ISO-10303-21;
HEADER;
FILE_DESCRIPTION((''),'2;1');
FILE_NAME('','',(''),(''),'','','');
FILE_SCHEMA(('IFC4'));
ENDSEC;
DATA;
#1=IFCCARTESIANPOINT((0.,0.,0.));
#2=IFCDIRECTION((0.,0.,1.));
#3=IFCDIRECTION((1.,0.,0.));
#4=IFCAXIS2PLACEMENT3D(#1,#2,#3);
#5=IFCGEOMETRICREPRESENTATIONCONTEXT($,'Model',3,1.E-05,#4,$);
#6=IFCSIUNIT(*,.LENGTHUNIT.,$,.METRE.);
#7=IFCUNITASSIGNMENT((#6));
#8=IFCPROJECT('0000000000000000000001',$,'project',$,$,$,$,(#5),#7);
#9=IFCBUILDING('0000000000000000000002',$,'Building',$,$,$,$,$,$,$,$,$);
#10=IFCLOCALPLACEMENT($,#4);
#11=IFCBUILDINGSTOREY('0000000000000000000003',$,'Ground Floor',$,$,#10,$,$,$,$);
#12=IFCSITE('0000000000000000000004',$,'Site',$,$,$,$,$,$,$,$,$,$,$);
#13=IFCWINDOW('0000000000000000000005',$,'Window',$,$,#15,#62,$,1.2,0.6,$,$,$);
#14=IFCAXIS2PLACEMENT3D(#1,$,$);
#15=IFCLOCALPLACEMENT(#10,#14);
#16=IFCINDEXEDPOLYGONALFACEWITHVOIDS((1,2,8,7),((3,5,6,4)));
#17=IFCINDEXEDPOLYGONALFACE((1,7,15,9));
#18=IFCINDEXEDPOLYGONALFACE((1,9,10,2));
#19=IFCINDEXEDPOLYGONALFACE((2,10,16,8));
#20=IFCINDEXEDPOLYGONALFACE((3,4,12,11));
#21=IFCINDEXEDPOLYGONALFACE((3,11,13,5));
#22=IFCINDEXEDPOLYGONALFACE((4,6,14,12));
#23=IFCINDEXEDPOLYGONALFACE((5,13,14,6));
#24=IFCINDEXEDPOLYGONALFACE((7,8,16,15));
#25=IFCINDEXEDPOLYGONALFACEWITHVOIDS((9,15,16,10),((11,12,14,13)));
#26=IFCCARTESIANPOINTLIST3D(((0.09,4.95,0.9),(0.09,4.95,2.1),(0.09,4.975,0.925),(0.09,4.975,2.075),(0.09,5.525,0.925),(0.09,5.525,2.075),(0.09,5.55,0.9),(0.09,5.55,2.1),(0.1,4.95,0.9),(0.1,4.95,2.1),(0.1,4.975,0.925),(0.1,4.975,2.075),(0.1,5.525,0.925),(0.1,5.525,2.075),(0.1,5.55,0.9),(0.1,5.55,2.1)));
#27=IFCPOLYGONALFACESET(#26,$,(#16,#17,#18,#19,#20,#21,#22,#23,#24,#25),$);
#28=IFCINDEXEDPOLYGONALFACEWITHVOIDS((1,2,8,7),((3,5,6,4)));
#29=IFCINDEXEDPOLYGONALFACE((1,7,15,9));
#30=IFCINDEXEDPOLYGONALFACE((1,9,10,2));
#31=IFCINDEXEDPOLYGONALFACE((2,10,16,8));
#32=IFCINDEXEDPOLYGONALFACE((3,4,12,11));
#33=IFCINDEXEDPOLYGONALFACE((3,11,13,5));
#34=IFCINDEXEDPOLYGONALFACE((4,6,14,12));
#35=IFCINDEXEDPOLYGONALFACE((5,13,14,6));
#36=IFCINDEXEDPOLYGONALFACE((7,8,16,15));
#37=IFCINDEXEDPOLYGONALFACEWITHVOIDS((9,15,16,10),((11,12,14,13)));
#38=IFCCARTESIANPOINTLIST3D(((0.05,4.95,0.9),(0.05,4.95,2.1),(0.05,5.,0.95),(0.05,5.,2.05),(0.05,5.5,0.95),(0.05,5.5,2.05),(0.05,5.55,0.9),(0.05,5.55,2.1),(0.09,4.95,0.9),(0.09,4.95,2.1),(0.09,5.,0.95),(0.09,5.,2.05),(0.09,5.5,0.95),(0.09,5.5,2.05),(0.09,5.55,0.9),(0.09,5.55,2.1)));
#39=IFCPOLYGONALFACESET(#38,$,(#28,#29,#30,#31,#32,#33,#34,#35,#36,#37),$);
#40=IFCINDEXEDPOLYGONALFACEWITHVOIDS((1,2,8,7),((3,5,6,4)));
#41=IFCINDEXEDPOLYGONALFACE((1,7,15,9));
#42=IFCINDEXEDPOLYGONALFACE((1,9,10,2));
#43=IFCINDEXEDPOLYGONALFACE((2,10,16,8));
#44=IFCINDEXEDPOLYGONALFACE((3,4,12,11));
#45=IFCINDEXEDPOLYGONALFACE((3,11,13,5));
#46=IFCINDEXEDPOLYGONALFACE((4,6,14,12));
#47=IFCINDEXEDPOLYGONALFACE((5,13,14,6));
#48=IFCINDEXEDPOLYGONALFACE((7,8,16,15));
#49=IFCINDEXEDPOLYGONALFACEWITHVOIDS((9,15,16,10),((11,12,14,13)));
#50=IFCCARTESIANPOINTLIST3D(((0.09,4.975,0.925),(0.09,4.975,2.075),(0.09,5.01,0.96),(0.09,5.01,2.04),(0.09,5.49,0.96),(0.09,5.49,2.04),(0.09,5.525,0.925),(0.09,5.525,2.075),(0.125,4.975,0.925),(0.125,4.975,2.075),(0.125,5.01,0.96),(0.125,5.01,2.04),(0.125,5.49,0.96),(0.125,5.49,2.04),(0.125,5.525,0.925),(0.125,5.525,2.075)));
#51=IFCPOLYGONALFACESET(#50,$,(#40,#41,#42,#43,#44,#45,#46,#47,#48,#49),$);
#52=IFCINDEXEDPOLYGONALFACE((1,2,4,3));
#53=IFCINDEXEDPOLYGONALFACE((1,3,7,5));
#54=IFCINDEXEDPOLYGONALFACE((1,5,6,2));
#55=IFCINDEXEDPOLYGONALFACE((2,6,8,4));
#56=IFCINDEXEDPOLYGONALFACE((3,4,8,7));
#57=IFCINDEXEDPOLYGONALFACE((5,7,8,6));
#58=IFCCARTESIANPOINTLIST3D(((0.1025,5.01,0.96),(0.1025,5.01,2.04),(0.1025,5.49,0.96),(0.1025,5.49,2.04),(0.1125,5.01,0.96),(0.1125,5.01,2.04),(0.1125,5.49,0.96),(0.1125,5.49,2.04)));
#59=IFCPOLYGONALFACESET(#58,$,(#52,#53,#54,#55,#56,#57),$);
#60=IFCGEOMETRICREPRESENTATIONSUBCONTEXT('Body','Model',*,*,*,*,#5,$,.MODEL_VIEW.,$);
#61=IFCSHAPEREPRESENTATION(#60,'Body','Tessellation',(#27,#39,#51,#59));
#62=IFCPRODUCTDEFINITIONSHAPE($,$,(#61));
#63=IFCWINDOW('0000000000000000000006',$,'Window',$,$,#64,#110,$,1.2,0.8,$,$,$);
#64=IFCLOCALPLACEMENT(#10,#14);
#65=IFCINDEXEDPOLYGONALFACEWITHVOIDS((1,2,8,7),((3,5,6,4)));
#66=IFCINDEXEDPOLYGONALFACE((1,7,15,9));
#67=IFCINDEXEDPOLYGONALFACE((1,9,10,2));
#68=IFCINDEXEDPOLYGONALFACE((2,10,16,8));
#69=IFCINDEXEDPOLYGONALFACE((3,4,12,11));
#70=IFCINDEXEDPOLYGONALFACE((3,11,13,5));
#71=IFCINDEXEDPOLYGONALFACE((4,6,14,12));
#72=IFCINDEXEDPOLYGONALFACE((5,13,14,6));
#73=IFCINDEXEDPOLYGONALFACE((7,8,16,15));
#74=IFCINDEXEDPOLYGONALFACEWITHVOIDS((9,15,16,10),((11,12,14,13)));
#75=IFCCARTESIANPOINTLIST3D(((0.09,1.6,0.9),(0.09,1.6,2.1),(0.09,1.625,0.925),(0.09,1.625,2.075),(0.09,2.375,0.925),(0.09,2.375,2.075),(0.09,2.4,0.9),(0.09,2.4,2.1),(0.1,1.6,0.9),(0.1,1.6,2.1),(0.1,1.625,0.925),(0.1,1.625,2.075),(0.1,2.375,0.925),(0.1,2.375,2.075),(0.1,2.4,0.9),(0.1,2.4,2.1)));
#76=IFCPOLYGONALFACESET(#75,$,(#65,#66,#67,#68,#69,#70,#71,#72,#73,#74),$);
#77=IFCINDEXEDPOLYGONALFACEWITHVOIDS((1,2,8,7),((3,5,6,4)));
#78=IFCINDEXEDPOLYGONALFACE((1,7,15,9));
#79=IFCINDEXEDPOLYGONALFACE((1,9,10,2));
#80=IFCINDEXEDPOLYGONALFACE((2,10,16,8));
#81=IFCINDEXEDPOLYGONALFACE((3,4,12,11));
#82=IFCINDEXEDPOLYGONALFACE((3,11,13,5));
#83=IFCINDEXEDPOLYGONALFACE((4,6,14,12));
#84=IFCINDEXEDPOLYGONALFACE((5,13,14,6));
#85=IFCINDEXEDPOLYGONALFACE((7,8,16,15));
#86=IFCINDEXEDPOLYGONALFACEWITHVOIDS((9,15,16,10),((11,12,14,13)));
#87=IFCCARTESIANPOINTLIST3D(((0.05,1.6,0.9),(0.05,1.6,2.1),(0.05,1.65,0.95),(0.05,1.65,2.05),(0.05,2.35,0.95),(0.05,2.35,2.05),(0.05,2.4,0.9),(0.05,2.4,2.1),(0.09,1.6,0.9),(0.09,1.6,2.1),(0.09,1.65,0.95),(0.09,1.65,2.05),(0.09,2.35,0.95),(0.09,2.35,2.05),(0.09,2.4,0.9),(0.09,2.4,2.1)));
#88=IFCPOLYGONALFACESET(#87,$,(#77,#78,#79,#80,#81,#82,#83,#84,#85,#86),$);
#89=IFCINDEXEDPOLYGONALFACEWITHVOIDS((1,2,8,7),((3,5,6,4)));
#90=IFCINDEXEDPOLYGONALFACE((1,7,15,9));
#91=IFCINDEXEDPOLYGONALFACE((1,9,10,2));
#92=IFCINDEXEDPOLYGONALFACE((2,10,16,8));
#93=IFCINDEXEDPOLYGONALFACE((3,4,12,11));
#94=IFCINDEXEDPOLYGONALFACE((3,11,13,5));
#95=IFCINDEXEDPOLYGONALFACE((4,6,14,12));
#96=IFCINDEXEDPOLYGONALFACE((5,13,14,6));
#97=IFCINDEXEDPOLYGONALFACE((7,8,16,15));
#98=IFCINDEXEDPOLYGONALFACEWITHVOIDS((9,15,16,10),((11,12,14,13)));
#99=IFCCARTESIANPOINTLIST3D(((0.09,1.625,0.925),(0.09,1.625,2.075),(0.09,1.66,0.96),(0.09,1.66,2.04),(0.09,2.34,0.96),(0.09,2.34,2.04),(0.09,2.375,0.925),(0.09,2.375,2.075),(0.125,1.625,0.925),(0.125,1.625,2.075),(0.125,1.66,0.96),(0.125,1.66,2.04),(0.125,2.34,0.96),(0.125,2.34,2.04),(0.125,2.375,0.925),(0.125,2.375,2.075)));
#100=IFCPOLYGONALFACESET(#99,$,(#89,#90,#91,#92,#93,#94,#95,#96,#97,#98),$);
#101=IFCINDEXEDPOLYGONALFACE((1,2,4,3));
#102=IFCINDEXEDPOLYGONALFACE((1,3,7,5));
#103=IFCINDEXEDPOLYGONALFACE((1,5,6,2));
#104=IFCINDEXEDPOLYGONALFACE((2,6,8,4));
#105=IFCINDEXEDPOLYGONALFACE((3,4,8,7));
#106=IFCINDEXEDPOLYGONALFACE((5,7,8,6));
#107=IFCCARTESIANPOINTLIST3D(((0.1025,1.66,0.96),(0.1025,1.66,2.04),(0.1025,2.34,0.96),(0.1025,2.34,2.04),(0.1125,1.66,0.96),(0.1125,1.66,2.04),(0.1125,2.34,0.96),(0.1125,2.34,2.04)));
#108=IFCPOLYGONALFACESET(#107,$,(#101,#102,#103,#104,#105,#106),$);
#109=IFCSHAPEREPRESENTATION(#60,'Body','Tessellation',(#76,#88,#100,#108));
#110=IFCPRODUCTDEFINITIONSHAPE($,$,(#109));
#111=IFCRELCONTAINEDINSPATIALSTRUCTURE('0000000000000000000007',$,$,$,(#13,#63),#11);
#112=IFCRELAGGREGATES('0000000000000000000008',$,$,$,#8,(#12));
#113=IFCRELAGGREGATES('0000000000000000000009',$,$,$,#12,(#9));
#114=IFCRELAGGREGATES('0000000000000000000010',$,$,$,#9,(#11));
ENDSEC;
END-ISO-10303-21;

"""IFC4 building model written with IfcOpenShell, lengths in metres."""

from ifc_helpers import new_model, si_unit, frame, origin_with_axes, place, context, subcontext, project, spatial, line, indexed_curve, outline, extrude, element, save


model = new_model("IFC4")

# Units and contexts
model_context = context("Model", 3, precision=1e-05, world=origin_with_axes())
body_context = subcontext(model_context, "Body", "Model", "MODEL_VIEW")
ifc_project = project(units=[si_unit("LENGTHUNIT", "METRE")], contexts=[model_context])

# Site, building, storey
site = spatial("IfcSite", under=ifc_project, Name="Site")
building = spatial("IfcBuilding", under=site, Name="Building")
storey_placement = place(None, origin_with_axes())
storey = spatial("IfcBuildingStorey", under=building, at=storey_placement, Name="Ground Floor")

# Windows
window_1_placement = place(storey_placement, frame((0.0, 5.55, 0.9), z_axis=(0.0, 0.0, 1.0), x_axis=(0.0, -1.0, 0.0)))
element("IfcWindow", 1, at=window_1_placement, inside=storey, Name="Window", OverallHeight=1.2, OverallWidth=0.6, context=body_context, shape_type="SweptSolid", body=[
    extrude(outline(indexed_curve([(0.0, 0.0), (0.6, 0.0), (0.6, 1.2), (0.0, 1.2)], segments=[line(1, 2, 3, 4, 1)]), holes=[indexed_curve([(0.025, 0.025), (0.575, 0.025), (0.575, 1.175), (0.025, 1.175)], segments=[line(1, 2, 3, 4, 1)])]), frame((0.0, 0.09, 0.0), z_axis=(0.0, -1.0, 0.0), x_axis=(1.0, 0.0, 0.0)), (0.0, 0.0, -1.0), 0.01),
    extrude(outline(indexed_curve([(0.0, 0.0), (0.6, 0.0), (0.6, 1.2), (0.0, 1.2)], segments=[line(1, 2, 3, 4, 1)]), holes=[indexed_curve([(0.05, 0.05), (0.55, 0.05), (0.55, 1.15), (0.05, 1.15)], segments=[line(1, 2, 3, 4, 1)])]), frame((0.0, 0.05, 0.0), z_axis=(0.0, -1.0, 0.0), x_axis=(1.0, 0.0, 0.0)), (0.0, 0.0, -1.0), 0.04),
    extrude(outline(indexed_curve([(0.0, 0.0), (0.55, 0.0), (0.55, 1.15), (0.0, 1.15)], segments=[line(1, 2, 3, 4, 1)]), holes=[indexed_curve([(0.035, 0.035), (0.515, 0.035), (0.515, 1.115), (0.035, 1.115)], segments=[line(1, 2, 3, 4, 1)])]), frame((0.025, 0.09, 0.025), z_axis=(0.0, -1.0, 0.0), x_axis=(1.0, 0.0, 0.0)), (0.0, 0.0, -1.0), 0.035),
    extrude(outline(indexed_curve([(0.035, 0.035), (0.515, 0.035), (0.515, 1.115), (0.035, 1.115)], segments=[line(1, 2, 3, 4, 1)])), frame((0.025, 0.1025, 0.025), z_axis=(0.0, -1.0, 0.0), x_axis=(1.0, 0.0, 0.0)), (0.0, 0.0, -1.0), 0.01),
])
window_2_placement = place(storey_placement, frame((0.0, 2.4, 0.9), z_axis=(0.0, 0.0, 1.0), x_axis=(0.0, -1.0, 0.0)))
element("IfcWindow", 2, at=window_2_placement, inside=storey, Name="Window", OverallHeight=1.2, OverallWidth=0.8, context=body_context, shape_type="SweptSolid", body=[
    extrude(outline(indexed_curve([(0.0, 0.0), (0.8, 0.0), (0.8, 1.2), (0.0, 1.2)], segments=[line(1, 2, 3, 4, 1)]), holes=[indexed_curve([(0.025, 0.025), (0.775, 0.025), (0.775, 1.175), (0.025, 1.175)], segments=[line(1, 2, 3, 4, 1)])]), frame((0.0, 0.09, 0.0), z_axis=(0.0, -1.0, 0.0), x_axis=(1.0, 0.0, 0.0)), (0.0, 0.0, -1.0), 0.01),
    extrude(outline(indexed_curve([(0.0, 0.0), (0.8, 0.0), (0.8, 1.2), (0.0, 1.2)], segments=[line(1, 2, 3, 4, 1)]), holes=[indexed_curve([(0.05, 0.05), (0.75, 0.05), (0.75, 1.15), (0.05, 1.15)], segments=[line(1, 2, 3, 4, 1)])]), frame((0.0, 0.05, 0.0), z_axis=(0.0, -1.0, 0.0), x_axis=(1.0, 0.0, 0.0)), (0.0, 0.0, -1.0), 0.04),
    extrude(outline(indexed_curve([(0.0, 0.0), (0.75, 0.0), (0.75, 1.15), (0.0, 1.15)], segments=[line(1, 2, 3, 4, 1)]), holes=[indexed_curve([(0.035, 0.035), (0.715, 0.035), (0.715, 1.115), (0.035, 1.115)], segments=[line(1, 2, 3, 4, 1)])]), frame((0.025, 0.09, 0.025), z_axis=(0.0, -1.0, 0.0), x_axis=(1.0, 0.0, 0.0)), (0.0, 0.0, -1.0), 0.035),
    extrude(outline(indexed_curve([(0.035, 0.035), (0.715, 0.035), (0.715, 1.115), (0.035, 1.115)], segments=[line(1, 2, 3, 4, 1)])), frame((0.025, 0.1025, 0.025), z_axis=(0.0, -1.0, 0.0), x_axis=(1.0, 0.0, 0.0)), (0.0, 0.0, -1.0), 0.01),
])

save(model, "model.ifc")
